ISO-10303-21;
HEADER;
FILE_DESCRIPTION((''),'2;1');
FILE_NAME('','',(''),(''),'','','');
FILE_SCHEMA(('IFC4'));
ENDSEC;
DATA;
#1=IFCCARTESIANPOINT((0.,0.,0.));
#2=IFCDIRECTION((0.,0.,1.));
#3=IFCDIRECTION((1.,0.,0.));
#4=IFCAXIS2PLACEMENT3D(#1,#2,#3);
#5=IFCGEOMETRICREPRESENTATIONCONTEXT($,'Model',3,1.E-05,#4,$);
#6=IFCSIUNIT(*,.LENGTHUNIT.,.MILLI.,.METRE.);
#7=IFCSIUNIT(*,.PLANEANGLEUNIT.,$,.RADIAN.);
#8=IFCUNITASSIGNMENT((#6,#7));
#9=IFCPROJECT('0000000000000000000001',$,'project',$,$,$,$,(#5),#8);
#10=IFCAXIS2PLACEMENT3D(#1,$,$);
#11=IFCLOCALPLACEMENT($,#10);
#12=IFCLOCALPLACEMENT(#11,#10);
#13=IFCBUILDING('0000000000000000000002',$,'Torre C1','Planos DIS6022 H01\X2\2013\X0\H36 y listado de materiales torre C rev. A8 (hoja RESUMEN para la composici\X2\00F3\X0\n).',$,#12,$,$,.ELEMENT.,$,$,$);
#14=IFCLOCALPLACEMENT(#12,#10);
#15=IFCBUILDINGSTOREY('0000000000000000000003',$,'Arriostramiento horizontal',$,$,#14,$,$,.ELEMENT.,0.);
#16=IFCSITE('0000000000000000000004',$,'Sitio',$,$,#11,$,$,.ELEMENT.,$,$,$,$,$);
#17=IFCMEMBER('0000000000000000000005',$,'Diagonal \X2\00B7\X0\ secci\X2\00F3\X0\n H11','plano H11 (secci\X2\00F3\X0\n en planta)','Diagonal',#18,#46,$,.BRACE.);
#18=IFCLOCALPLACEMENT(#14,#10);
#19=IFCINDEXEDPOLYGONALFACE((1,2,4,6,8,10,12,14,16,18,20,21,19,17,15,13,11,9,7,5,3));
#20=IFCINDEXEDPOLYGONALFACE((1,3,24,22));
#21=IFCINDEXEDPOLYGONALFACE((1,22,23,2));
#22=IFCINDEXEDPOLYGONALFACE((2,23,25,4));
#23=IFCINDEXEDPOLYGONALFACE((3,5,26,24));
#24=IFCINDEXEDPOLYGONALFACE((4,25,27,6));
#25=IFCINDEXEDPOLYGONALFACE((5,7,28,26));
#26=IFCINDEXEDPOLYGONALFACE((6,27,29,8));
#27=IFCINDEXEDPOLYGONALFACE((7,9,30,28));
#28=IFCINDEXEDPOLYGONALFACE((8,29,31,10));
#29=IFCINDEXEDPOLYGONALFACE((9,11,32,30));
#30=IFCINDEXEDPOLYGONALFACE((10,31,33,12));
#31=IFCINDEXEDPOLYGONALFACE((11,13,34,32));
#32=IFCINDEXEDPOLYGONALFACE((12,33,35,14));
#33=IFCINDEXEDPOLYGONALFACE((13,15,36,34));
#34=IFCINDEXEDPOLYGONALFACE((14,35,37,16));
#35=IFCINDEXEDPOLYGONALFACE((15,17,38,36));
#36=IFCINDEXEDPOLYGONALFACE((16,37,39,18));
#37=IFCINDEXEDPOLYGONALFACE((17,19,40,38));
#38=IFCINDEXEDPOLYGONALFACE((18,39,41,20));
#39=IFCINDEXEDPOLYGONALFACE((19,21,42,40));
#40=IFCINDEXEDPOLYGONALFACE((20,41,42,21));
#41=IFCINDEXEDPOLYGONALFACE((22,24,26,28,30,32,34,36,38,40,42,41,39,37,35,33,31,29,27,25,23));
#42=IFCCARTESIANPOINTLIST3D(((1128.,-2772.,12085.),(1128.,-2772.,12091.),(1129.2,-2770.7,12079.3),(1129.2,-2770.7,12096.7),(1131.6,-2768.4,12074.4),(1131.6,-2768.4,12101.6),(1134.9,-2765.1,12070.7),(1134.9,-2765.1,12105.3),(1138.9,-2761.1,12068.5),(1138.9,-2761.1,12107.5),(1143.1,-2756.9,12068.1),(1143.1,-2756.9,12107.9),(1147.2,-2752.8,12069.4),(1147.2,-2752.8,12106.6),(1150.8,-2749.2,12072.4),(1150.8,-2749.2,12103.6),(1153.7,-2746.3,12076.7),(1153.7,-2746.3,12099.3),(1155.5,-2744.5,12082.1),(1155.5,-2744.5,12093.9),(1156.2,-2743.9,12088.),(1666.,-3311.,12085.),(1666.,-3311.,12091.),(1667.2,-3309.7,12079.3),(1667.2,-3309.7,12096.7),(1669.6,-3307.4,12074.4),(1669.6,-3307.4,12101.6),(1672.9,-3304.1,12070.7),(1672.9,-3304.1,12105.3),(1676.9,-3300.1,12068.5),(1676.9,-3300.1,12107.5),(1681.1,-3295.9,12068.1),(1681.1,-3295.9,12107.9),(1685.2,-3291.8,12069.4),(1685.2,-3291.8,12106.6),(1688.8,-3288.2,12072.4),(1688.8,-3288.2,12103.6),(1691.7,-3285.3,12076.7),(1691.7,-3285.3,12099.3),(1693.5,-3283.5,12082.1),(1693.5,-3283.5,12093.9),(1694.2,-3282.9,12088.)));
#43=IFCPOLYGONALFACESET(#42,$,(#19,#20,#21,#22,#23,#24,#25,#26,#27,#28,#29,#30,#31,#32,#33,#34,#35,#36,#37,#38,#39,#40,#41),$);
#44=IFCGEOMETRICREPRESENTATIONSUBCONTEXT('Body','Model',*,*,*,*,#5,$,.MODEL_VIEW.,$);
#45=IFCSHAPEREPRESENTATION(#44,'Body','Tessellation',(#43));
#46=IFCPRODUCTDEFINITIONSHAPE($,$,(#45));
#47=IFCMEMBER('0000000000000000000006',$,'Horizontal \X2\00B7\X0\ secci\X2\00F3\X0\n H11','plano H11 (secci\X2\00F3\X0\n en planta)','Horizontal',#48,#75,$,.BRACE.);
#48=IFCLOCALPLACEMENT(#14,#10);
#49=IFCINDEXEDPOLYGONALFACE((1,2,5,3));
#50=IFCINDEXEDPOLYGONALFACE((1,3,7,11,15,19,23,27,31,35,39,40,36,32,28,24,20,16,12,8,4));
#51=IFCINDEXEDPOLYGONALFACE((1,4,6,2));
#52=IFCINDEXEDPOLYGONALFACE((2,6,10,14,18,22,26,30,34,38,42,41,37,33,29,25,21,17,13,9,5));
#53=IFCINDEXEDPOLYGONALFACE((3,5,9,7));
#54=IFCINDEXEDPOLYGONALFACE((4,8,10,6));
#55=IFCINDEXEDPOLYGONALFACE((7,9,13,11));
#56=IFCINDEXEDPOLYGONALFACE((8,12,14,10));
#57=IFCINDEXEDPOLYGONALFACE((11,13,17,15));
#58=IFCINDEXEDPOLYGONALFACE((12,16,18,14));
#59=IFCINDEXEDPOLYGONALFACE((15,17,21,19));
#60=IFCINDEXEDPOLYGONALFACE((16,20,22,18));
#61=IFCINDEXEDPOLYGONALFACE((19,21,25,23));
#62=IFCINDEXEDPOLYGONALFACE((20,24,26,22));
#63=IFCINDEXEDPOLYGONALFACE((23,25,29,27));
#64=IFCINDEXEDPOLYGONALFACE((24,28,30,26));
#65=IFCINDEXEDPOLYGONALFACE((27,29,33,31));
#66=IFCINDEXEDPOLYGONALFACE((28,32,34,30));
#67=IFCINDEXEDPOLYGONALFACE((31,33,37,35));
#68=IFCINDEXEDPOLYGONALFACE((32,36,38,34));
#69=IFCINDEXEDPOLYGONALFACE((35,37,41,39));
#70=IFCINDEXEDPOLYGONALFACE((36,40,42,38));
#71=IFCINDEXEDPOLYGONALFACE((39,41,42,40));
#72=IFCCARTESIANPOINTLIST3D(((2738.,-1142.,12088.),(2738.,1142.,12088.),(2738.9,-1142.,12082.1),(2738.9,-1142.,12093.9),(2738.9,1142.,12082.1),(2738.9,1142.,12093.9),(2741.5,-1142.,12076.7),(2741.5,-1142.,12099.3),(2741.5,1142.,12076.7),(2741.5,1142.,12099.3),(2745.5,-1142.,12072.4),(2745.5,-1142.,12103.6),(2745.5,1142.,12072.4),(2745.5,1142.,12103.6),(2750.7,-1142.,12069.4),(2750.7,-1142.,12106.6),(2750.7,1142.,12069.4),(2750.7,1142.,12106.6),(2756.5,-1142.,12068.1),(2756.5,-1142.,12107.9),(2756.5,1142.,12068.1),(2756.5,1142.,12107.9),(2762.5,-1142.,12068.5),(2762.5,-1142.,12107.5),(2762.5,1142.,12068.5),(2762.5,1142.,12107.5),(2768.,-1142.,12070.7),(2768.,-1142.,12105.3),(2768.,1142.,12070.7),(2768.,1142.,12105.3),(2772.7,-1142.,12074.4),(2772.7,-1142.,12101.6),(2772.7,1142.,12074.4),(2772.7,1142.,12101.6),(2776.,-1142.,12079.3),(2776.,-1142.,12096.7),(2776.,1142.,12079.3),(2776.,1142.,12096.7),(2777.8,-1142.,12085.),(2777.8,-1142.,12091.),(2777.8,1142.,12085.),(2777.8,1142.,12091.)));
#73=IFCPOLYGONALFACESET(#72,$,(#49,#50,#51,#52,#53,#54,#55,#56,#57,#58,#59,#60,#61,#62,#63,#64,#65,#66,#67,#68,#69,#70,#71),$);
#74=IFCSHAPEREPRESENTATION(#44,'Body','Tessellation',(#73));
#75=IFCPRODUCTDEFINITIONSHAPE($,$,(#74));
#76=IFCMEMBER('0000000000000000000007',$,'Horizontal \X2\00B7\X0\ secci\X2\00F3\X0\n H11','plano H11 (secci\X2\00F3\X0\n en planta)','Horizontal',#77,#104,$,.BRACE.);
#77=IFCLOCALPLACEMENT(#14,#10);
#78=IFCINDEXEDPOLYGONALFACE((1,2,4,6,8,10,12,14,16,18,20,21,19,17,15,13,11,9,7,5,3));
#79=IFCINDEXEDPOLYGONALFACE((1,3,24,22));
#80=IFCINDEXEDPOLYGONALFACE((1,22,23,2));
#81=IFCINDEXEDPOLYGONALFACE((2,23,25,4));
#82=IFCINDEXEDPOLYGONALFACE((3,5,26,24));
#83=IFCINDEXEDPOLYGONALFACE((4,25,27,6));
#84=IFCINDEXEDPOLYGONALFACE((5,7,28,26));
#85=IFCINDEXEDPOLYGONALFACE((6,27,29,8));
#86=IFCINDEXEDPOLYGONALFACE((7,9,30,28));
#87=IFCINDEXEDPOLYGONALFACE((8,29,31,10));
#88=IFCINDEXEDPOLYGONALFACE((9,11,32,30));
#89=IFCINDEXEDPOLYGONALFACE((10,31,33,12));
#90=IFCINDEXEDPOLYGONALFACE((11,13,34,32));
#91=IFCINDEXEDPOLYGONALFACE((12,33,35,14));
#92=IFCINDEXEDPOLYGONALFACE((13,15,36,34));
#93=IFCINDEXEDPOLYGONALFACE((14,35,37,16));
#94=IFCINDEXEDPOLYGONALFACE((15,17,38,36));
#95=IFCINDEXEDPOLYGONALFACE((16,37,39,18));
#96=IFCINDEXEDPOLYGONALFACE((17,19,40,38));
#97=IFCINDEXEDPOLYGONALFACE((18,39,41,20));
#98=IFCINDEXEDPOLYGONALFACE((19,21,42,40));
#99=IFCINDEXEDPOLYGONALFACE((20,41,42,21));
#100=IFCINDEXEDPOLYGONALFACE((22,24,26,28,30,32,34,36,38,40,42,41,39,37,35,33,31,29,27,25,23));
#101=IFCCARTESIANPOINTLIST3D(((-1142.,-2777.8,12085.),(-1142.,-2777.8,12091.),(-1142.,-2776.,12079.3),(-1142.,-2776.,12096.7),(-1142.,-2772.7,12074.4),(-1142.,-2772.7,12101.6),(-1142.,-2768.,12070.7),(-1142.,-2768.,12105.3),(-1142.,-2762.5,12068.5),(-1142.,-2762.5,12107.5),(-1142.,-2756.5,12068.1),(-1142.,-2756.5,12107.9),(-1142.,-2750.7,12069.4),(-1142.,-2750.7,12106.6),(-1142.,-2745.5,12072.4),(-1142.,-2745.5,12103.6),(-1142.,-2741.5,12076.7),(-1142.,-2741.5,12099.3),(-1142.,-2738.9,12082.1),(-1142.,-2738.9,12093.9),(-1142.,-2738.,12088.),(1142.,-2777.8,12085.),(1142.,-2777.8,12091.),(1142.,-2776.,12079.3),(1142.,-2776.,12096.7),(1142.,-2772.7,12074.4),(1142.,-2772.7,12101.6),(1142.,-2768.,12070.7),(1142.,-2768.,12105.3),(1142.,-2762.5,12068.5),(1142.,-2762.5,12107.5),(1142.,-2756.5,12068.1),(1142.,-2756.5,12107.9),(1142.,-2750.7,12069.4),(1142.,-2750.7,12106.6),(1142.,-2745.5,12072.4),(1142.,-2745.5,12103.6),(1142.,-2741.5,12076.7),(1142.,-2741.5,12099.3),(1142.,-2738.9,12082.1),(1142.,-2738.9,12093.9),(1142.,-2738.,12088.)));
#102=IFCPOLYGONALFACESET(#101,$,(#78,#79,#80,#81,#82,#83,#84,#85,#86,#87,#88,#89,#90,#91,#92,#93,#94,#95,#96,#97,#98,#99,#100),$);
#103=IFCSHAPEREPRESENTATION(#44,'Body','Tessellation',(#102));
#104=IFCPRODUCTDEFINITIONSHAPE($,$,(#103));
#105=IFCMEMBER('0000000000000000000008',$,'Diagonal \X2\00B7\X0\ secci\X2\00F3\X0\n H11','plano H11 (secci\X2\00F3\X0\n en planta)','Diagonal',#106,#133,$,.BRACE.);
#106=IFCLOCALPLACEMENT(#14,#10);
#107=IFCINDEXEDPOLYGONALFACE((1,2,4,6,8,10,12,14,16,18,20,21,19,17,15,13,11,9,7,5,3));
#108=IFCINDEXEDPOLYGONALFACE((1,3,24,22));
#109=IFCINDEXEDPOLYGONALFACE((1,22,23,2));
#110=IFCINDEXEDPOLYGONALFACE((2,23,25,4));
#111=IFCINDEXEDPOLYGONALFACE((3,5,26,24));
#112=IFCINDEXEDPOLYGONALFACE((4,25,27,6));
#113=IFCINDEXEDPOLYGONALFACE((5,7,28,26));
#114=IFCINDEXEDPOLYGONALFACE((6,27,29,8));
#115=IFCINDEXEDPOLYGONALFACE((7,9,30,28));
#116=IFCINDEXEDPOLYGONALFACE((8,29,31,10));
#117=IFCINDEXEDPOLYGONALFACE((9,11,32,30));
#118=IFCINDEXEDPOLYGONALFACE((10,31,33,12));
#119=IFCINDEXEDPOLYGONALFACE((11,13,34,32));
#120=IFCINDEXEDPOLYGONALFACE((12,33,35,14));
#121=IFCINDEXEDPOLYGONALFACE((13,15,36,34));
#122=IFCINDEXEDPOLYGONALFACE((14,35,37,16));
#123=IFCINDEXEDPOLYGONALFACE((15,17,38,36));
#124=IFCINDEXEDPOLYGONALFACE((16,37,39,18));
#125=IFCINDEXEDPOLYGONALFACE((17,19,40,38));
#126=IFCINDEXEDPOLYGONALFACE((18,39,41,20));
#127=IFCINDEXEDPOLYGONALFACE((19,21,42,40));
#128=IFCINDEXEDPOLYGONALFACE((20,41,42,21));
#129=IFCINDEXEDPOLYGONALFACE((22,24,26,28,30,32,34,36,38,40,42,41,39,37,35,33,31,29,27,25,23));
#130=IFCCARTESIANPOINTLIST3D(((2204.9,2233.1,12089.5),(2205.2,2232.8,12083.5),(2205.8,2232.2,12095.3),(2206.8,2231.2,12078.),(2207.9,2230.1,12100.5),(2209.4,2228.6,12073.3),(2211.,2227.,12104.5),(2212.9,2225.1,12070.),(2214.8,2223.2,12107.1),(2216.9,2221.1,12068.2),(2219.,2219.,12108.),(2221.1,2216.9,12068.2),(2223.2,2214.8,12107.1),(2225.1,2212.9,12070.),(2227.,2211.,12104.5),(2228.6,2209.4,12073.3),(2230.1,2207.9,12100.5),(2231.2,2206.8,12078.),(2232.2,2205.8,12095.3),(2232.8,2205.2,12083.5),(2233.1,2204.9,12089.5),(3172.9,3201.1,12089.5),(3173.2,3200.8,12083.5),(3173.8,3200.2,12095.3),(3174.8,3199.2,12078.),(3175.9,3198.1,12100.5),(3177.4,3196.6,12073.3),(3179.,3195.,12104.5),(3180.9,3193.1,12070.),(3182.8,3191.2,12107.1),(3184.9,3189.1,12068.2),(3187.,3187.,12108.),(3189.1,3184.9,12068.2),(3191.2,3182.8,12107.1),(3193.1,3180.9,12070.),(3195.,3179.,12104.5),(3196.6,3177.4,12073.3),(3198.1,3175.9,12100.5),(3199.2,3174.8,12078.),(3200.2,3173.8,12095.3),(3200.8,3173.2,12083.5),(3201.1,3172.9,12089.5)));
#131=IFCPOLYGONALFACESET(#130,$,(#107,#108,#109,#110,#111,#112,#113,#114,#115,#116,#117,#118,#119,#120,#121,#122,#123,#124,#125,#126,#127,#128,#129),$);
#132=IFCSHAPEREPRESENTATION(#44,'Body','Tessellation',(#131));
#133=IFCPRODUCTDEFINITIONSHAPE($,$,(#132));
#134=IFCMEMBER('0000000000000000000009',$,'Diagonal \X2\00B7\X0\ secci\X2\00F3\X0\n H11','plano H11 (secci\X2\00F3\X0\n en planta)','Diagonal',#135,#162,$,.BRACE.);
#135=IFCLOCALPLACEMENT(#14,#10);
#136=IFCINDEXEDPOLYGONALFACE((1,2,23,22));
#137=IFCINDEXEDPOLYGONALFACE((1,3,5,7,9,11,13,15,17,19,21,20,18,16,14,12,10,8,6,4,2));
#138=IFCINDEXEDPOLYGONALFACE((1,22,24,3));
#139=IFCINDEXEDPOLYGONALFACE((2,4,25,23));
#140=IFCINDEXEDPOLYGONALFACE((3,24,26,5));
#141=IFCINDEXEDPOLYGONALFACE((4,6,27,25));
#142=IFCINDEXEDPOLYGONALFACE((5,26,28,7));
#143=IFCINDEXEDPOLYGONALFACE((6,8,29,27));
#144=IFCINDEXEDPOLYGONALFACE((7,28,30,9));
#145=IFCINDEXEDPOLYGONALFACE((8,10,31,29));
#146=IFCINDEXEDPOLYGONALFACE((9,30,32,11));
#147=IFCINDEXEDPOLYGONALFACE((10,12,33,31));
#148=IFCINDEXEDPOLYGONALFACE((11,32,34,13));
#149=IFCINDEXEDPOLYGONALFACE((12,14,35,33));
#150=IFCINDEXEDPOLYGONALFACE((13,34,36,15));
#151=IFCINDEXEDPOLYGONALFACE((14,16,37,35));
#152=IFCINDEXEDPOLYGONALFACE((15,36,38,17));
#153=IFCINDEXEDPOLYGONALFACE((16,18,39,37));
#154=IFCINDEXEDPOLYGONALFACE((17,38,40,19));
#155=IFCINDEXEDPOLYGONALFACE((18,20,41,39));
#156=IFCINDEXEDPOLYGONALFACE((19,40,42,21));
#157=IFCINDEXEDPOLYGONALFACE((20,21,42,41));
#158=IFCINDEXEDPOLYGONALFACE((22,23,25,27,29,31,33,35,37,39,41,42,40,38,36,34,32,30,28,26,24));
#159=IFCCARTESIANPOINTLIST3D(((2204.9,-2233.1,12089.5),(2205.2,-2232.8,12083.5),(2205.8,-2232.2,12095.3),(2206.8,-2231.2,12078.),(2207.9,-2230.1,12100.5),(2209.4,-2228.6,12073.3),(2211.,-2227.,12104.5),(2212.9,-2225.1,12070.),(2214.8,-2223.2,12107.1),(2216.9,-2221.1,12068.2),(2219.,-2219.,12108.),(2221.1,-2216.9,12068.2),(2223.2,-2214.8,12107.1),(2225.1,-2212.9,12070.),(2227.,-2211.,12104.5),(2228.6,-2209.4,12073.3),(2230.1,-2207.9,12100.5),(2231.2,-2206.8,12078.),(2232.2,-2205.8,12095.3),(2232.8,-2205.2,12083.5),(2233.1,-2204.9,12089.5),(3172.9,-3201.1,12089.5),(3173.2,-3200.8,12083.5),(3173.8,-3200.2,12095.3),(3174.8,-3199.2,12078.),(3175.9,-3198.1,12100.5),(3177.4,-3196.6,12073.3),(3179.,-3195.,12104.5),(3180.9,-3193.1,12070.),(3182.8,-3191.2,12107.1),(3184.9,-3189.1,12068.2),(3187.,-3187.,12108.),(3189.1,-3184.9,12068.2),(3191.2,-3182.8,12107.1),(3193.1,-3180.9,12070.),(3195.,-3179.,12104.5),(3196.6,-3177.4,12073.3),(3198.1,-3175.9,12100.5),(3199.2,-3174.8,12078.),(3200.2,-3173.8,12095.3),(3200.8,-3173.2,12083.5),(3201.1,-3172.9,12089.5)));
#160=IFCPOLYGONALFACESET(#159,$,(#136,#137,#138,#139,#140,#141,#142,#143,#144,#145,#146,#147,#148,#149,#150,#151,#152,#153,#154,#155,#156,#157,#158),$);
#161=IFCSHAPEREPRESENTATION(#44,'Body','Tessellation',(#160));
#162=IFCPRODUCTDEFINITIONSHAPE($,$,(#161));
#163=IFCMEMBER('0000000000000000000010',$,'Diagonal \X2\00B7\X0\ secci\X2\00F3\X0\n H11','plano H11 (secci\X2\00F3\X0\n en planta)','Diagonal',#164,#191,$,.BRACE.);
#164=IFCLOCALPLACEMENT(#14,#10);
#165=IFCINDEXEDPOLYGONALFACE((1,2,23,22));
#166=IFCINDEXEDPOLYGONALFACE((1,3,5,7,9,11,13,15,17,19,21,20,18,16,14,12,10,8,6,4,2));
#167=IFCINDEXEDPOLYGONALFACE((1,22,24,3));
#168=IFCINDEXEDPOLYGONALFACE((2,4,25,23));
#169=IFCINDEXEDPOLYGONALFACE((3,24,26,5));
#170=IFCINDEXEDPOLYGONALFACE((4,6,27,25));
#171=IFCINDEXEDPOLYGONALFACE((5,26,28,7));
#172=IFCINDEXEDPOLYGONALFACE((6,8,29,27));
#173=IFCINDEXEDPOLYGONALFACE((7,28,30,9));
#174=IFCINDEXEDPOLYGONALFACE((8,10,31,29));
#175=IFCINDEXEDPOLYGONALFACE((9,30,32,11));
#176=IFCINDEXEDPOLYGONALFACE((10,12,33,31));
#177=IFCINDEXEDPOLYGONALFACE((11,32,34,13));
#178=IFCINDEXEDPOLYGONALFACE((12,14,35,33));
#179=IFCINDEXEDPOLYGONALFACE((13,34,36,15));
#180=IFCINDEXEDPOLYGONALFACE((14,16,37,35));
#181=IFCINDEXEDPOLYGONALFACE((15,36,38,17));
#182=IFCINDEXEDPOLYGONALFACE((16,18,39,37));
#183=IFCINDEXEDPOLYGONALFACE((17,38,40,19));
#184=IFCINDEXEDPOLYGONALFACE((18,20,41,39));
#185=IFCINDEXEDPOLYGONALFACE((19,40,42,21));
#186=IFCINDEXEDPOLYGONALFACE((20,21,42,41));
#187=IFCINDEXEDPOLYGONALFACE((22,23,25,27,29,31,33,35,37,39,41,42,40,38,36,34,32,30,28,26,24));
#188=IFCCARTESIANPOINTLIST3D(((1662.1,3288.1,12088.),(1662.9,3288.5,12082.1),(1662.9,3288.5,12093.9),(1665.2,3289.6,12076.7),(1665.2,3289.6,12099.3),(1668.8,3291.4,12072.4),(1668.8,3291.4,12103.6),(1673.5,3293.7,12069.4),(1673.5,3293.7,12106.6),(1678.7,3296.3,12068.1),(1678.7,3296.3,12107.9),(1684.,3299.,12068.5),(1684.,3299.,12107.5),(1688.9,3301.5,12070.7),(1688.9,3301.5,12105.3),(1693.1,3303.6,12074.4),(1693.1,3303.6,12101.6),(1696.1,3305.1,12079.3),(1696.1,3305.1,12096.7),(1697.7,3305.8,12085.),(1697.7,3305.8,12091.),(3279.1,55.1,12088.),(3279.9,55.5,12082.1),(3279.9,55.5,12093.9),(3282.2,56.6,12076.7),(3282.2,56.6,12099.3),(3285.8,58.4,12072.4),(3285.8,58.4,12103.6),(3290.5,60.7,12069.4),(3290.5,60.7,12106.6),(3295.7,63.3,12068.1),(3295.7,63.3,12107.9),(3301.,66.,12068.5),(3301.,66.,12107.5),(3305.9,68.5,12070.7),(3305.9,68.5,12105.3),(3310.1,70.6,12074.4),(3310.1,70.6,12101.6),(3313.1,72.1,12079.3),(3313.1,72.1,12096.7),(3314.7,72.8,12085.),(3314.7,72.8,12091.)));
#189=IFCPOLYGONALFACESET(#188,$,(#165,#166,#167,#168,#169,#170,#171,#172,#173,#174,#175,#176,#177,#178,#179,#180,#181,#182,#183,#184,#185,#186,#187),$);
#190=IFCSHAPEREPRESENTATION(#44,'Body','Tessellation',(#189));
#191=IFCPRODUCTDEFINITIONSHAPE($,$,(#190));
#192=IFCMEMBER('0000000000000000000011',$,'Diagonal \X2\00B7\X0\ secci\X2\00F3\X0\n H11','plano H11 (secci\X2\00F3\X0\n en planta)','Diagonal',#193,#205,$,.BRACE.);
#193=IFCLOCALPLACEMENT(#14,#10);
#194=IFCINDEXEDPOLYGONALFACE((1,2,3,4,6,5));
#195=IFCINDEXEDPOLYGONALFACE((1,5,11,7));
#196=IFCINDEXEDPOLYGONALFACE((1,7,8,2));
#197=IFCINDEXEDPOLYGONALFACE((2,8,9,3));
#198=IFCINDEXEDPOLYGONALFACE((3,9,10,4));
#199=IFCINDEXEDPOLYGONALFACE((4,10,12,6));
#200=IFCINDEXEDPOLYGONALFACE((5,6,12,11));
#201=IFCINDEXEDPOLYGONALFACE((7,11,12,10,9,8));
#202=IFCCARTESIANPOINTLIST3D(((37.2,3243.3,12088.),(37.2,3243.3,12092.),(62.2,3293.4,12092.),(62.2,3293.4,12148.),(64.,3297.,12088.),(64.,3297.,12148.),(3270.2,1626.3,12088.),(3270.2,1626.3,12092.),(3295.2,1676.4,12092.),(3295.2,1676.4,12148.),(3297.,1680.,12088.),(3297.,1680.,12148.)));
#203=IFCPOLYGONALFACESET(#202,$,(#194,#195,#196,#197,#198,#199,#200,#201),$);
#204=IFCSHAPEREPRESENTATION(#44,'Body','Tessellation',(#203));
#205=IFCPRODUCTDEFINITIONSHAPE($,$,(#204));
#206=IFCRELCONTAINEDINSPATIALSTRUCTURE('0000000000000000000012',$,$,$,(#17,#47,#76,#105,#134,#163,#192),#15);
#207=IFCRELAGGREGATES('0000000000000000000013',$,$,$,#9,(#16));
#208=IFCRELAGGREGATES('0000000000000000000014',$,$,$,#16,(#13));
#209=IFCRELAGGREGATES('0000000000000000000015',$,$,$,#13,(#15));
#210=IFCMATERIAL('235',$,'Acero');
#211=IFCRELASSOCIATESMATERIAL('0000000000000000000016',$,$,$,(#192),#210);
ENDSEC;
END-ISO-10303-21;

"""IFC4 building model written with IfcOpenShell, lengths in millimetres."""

from ifc_helpers import new_model, si_unit, frame, frame_2d, origin, origin_with_axes, place, context, subcontext, project, spatial, circle, l_section, extrude, material, element, save


model = new_model("IFC4")

# Units and contexts
model_context = context("Model", 3, precision=1e-05, world=origin_with_axes())
body_context = subcontext(model_context, "Body", "Model", "MODEL_VIEW")
ifc_project = project(units=[si_unit("LENGTHUNIT", "METRE", prefix="MILLI"), si_unit("PLANEANGLEUNIT", "RADIAN")], contexts=[model_context])

# Site, building, storey
site_placement = place(None, origin())
site = spatial("IfcSite", under=ifc_project, at=site_placement, Name="Sitio", CompositionType="ELEMENT")
building_placement = place(site_placement, origin())
building = spatial("IfcBuilding", under=site, at=building_placement, Name="Torre C1", Description="Planos DIS6022 H01–H36 y listado de materiales torre C rev. A8 (hoja RESUMEN para la composición).", CompositionType="ELEMENT")
storey_placement = place(building_placement, origin())
storey = spatial("IfcBuildingStorey", under=building, at=storey_placement, Name="Arriostramiento horizontal", CompositionType="ELEMENT", Elevation=0.0)

# Members
for number, where, z_axis, x_axis, name in (
    (1, (1680.0, -3297.0, 12088.0), (-0.70645, 0.707763, 0.0), (0.707763, 0.70645, 0.0), "Diagonal · sección H11"),
):
    element("IfcMember", number, at=place(storey_placement, frame(where, z_axis=z_axis, x_axis=x_axis)), inside=storey, Name=name, Description="plano H11 (sección en planta)", ObjectType="Diagonal", PredefinedType="BRACE", context=body_context, shape_type="SweptSolid", body=[
        extrude(circle(Radius=20.0), None, (0.0, 0.0, 1.0), 761.6),
    ])
for number, where, z_axis, x_axis, name in (
    (2, (2758.0, 1142.0, 12088.0), (0.0, -1.0, 0.0), (-1.0, 0.0, 0.0), "Horizontal · sección H11"),
    (3, (1142.0, -2758.0, 12088.0), (-1.0, 0.0, 0.0), (0.0, 1.0, 0.0), "Horizontal · sección H11"),
):
    element("IfcMember", number, at=place(storey_placement, frame(where, z_axis=z_axis, x_axis=x_axis)), inside=storey, Name=name, Description="plano H11 (sección en planta)", ObjectType="Horizontal", PredefinedType="BRACE", context=body_context, shape_type="SweptSolid", body=[
        extrude(circle(Radius=20.0), None, (0.0, 0.0, 1.0), 2284.0),
    ])
for number, where, z_axis, x_axis, name in (
    (4, (3187.0, 3187.0, 12088.0), (-0.707107, -0.707107, 0.0), (0.0, 0.0, 1.0), "Diagonal · sección H11"),
    (5, (3187.0, -3187.0, 12088.0), (-0.707107, 0.707107, 0.0), (0.0, 0.0, 1.0), "Diagonal · sección H11"),
):
    element("IfcMember", number, at=place(storey_placement, frame(where, z_axis=z_axis, x_axis=x_axis)), inside=storey, Name=name, Description="plano H11 (sección en planta)", ObjectType="Diagonal", PredefinedType="BRACE", context=body_context, shape_type="SweptSolid", body=[
        extrude(circle(Radius=20.0), None, (0.0, 0.0, 1.0), 1369.0),
    ])
member_1_placement = place(storey_placement, frame((3297.0, 64.0, 12088.0), z_axis=(-0.447324, 0.894372, 0.0), x_axis=(-0.894372, -0.447324, 0.0)))
element("IfcMember", 6, at=member_1_placement, inside=storey, Name="Diagonal · sección H11", Description="plano H11 (sección en planta)", ObjectType="Diagonal", PredefinedType="BRACE", context=body_context, shape_type="SweptSolid", body=[
    extrude(circle(Radius=20.0), None, (0.0, 0.0, 1.0), 3614.8),
])
ifc_material = material(Name="235", Category="Acero")
member_2_placement = place(storey_placement, frame((3297.0, 1680.0, 12088.0), z_axis=(-0.894372, 0.447324, 0.0), x_axis=(-0.447324, -0.894372, 0.0)))
element("IfcMember", 7, at=member_2_placement, inside=storey, material=ifc_material, Name="Diagonal · sección H11", Description="plano H11 (sección en planta)", ObjectType="Diagonal", PredefinedType="BRACE", context=body_context, shape_type="SweptSolid", body=[
    extrude(l_section(Depth=60.0, Width=60.0, Thickness=4.0, at=frame_2d((30.0, 30.0))), None, (0.0, 0.0, 1.0), 3614.8),
])

save(model, "model.ifc")
